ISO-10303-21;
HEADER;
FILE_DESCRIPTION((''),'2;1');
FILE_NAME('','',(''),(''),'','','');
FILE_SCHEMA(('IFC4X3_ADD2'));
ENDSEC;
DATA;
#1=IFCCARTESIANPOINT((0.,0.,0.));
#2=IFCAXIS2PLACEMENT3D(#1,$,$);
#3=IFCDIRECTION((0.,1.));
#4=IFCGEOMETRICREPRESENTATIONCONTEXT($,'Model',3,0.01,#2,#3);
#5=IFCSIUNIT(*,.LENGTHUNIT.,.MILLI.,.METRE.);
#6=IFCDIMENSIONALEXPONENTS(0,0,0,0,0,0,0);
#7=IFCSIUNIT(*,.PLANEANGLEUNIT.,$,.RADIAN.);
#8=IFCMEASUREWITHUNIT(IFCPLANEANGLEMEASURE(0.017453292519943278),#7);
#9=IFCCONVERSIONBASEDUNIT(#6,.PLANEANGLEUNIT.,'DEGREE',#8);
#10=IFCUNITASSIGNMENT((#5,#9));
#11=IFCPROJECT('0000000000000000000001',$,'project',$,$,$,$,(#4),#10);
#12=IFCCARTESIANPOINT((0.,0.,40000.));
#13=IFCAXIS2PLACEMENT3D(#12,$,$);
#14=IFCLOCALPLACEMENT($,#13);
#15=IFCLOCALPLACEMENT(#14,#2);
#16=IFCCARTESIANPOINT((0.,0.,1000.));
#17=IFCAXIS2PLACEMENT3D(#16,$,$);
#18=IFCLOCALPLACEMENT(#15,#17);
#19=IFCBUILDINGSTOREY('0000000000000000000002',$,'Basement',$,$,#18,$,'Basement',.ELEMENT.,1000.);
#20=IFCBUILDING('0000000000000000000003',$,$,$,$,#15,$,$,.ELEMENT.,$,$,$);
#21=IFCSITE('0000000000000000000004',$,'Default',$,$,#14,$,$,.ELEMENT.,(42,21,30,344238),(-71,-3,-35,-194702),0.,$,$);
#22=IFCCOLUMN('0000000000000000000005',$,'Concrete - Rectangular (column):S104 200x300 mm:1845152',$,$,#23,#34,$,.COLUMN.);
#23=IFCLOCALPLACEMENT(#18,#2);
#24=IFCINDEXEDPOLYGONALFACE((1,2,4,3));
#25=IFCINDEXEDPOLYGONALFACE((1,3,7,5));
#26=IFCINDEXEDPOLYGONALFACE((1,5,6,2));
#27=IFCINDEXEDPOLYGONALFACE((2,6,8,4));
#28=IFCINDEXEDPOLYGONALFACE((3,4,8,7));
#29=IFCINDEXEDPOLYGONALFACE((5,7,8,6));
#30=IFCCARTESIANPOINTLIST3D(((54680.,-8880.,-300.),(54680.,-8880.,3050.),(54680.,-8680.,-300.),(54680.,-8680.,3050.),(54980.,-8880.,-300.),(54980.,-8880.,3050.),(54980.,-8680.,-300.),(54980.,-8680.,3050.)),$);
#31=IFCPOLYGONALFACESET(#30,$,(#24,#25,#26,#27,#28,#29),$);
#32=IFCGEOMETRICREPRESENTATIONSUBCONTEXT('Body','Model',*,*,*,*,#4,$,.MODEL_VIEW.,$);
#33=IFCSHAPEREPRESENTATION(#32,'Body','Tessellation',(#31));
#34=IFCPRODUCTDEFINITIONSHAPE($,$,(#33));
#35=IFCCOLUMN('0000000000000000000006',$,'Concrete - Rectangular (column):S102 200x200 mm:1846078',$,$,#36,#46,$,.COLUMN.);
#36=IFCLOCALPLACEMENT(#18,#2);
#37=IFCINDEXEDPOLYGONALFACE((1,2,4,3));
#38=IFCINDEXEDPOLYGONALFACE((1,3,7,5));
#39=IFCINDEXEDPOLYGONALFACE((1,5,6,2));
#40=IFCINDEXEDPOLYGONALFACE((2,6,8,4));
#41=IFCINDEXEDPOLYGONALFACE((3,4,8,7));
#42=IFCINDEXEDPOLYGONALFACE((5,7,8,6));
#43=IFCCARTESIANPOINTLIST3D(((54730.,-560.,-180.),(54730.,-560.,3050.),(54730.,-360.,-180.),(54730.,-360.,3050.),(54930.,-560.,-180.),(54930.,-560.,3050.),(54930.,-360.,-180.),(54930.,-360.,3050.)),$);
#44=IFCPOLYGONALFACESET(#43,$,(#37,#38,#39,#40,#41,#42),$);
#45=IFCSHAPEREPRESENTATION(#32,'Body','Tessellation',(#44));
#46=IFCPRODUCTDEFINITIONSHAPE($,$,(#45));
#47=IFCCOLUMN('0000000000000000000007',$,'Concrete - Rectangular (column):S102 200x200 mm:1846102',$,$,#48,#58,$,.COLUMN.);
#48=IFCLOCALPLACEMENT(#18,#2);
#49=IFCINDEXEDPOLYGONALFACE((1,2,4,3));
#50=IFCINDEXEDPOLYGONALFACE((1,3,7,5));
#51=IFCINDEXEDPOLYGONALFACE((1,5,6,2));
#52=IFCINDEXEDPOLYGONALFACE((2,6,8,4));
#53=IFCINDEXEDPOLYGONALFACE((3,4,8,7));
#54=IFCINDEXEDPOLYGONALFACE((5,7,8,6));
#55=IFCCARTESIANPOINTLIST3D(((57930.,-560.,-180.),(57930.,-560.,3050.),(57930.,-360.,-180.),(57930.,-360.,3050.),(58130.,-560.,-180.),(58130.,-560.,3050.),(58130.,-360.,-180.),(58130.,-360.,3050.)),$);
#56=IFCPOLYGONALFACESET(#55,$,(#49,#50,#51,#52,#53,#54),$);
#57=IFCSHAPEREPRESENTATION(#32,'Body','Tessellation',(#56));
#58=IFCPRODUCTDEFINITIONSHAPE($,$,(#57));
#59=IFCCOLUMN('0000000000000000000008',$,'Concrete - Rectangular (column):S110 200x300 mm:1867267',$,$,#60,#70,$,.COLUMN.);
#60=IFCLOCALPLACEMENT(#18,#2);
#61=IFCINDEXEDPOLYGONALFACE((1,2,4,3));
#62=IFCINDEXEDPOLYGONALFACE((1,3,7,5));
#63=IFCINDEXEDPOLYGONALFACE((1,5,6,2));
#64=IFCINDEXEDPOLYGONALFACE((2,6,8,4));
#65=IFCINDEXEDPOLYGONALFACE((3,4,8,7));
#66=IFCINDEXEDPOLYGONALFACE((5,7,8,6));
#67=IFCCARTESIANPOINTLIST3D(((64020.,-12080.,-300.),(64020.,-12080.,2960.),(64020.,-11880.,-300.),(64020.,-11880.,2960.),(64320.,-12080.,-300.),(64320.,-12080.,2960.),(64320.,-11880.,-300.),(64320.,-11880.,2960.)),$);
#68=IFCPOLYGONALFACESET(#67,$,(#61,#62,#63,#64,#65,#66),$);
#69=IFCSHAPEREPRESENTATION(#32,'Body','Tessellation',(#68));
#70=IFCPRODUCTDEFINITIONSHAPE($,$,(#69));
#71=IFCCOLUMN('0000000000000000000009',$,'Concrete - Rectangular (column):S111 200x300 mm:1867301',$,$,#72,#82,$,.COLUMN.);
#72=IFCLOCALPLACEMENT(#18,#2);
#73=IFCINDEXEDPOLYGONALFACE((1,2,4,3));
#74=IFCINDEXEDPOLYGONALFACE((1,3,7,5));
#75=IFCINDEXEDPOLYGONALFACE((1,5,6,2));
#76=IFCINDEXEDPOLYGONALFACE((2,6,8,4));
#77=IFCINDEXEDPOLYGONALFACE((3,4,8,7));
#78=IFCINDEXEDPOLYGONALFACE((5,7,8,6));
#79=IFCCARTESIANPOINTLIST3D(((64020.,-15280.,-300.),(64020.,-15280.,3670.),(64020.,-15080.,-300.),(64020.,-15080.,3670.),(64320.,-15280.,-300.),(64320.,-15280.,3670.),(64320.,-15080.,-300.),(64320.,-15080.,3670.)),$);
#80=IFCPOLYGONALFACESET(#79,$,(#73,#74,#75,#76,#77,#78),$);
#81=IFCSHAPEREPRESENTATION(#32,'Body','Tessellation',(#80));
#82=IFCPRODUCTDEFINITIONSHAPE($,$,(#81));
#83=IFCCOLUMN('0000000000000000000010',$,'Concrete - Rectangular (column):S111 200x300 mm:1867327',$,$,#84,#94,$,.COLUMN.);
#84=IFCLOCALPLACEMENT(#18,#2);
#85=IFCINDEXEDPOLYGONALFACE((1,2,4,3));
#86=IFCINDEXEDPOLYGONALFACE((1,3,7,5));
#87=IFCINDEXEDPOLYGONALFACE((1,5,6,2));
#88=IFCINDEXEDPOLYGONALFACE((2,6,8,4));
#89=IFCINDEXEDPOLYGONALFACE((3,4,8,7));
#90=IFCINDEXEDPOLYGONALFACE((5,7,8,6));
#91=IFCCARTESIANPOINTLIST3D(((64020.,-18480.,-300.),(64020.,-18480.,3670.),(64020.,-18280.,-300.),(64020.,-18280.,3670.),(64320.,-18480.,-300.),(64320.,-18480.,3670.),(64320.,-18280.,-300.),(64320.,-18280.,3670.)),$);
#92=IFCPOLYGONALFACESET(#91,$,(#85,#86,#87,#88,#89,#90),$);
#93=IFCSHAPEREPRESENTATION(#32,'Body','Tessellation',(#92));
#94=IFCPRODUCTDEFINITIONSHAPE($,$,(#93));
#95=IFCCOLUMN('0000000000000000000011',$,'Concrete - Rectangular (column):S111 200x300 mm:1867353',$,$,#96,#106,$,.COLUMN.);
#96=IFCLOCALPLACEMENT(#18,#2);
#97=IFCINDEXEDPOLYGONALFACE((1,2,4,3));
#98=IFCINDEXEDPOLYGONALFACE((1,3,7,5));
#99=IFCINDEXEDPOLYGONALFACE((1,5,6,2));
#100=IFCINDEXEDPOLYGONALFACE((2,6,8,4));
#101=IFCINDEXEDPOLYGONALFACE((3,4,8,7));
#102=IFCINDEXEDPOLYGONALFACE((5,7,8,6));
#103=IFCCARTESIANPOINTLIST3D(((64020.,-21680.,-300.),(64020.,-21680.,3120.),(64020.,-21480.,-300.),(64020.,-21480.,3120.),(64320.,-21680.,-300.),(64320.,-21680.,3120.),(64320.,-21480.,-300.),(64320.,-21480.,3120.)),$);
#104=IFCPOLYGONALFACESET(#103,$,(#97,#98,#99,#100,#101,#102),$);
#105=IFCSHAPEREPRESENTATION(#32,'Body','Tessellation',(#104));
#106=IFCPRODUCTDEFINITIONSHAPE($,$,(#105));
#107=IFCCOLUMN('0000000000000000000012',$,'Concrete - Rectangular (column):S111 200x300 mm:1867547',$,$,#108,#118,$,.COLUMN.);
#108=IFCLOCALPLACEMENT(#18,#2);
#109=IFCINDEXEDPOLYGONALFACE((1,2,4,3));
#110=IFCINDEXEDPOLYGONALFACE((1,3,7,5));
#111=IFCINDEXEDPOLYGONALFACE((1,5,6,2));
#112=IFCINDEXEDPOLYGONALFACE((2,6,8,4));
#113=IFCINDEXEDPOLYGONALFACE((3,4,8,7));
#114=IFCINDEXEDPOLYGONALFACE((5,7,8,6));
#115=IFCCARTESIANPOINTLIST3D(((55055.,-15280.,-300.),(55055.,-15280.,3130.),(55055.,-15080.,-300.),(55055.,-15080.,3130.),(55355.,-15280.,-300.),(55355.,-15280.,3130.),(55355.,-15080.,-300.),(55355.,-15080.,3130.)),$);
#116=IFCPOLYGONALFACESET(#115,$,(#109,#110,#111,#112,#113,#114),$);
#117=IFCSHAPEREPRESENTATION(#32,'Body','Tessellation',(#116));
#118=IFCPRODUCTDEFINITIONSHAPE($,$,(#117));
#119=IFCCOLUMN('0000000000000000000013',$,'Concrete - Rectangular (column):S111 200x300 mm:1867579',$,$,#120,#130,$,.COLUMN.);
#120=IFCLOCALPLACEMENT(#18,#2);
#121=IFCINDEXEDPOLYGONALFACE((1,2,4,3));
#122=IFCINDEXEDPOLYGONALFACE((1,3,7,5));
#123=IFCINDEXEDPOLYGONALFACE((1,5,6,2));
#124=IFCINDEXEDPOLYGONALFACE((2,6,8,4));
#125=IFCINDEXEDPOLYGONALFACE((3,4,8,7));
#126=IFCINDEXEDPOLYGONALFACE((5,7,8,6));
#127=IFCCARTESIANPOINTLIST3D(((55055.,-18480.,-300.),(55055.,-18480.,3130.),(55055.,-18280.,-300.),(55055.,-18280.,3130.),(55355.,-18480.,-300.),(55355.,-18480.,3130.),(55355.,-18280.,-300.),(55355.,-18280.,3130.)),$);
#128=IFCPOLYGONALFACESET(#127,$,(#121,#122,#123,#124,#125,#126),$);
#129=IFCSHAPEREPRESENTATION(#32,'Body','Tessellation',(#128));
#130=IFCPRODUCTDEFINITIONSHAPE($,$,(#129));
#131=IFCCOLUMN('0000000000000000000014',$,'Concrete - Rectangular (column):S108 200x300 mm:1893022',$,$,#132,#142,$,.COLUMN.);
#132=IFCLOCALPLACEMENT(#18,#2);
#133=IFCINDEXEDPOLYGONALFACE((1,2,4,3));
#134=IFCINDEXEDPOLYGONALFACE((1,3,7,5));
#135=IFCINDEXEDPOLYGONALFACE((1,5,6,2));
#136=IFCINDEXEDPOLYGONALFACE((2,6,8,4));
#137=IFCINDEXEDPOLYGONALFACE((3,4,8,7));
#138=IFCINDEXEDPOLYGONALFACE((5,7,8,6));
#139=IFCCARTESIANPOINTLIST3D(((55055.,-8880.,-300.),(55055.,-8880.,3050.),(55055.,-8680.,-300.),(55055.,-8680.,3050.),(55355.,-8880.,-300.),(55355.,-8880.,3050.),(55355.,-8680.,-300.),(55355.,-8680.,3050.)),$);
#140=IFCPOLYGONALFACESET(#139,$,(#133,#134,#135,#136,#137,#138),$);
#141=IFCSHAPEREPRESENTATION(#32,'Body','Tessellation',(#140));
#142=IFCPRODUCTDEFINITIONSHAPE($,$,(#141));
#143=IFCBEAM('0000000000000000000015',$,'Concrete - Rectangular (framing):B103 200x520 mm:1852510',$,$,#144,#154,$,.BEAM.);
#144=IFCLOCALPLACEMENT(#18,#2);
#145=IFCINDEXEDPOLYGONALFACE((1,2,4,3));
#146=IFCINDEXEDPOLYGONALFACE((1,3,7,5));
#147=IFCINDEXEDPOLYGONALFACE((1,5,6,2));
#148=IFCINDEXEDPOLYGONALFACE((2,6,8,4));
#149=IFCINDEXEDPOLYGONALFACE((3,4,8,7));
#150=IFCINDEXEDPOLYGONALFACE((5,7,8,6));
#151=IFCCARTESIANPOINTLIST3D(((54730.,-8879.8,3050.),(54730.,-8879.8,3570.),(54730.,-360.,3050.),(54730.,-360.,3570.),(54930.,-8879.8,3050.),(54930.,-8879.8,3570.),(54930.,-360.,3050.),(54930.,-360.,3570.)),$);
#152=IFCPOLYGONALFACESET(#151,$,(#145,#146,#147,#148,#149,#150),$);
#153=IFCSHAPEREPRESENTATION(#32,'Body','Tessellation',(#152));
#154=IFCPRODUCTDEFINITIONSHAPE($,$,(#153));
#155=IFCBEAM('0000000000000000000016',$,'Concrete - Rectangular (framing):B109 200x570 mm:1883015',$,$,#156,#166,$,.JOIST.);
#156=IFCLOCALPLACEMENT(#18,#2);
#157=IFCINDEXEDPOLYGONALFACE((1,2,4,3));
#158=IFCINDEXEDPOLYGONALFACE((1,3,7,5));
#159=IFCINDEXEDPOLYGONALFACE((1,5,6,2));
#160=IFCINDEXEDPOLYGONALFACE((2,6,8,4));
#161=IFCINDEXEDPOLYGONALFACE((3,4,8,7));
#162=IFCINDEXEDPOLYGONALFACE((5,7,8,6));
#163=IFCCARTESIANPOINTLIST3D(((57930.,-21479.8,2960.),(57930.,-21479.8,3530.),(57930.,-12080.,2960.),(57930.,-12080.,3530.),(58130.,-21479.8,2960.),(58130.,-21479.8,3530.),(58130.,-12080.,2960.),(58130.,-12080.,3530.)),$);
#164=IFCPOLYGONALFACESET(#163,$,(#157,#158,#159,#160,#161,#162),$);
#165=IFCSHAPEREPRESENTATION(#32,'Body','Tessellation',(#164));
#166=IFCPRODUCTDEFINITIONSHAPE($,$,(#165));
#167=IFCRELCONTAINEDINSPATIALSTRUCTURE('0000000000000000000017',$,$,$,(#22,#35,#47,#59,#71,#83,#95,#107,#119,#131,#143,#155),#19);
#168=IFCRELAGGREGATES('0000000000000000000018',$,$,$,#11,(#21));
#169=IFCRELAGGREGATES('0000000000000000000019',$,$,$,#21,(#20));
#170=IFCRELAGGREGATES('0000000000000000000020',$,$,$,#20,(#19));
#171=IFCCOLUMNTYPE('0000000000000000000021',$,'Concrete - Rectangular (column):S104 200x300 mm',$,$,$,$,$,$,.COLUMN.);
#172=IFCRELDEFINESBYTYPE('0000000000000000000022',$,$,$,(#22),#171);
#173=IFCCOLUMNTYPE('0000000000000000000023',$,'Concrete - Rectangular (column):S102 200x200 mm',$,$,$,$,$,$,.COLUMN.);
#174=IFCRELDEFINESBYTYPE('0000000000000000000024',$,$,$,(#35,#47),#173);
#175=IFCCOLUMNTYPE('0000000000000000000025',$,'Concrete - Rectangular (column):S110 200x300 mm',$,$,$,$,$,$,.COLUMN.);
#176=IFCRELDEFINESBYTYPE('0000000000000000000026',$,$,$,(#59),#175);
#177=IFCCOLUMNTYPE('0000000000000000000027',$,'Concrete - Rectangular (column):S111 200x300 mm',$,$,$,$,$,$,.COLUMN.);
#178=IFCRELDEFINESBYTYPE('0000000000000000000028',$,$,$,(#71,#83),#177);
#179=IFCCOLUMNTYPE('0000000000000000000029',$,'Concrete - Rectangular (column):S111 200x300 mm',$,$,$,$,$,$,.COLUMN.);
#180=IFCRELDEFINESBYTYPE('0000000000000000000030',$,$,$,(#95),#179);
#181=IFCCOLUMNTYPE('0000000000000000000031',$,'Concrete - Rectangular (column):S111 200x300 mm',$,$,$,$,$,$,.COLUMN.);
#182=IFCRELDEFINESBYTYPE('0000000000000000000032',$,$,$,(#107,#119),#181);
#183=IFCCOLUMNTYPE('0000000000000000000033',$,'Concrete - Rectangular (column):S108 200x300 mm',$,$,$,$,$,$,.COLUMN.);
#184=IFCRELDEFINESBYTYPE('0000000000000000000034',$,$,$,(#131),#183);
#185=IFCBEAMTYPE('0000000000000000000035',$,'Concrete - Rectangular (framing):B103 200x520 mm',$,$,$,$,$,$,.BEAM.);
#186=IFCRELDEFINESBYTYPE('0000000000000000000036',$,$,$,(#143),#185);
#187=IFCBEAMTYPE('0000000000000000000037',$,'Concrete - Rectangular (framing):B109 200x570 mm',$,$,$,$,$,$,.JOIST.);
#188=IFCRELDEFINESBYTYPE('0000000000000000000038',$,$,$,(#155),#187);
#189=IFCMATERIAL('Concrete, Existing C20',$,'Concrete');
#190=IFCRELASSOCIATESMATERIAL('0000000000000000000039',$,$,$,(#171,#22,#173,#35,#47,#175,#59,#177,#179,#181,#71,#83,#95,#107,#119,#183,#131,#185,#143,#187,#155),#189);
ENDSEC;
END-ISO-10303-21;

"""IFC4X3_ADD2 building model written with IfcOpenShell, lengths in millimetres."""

from ifc_helpers import new_model, entity, si_unit, converted_unit, direction, frame, frame_2d, origin, origin_2d_with_axis, place, context, subcontext, project, spatial, rectangle, extrude, source, transform, mapped, material, material_profile, profile_set, profile_usage, type_object, type_shapes, element, save


model = new_model("IFC4X3_ADD2")

# Units and contexts
model_context = context("Model", 3, precision=0.01, world=origin(), true_north=direction((0.0, 1.0)))
body_context = subcontext(model_context, "Body", "Model", "MODEL_VIEW")
ifc_project = project(units=[si_unit("LENGTHUNIT", "METRE", prefix="MILLI"), converted_unit("PLANEANGLEUNIT", "DEGREE", entity("IfcPlaneAngleMeasure", 0.017453292519943278), si_unit("PLANEANGLEUNIT", "RADIAN"), dimensions=[0, 0, 0, 0, 0, 0, 0])], contexts=[model_context])

# Site, building, storey
site_placement = place(None, frame((0.0, 0.0, 40000.0)))
site = spatial("IfcSite", under=ifc_project, at=site_placement, Name="Default", CompositionType="ELEMENT", RefLatitude=(42, 21, 30, 344238), RefLongitude=(-71, -3, -35, -194702), RefElevation=0.0)
building_placement = place(site_placement, origin())
building = spatial("IfcBuilding", under=site, at=building_placement, CompositionType="ELEMENT")
storey_placement = place(building_placement, frame((0.0, 0.0, 1000.0)))
storey = spatial("IfcBuildingStorey", under=building, at=storey_placement, Name="Basement", LongName="Basement", CompositionType="ELEMENT", Elevation=1000.0)

# Columns
ifc_material_1 = material(Name="Concrete, Existing C20", Category="Concrete")
ifc_material_profile_1 = material_profile(ifc_material_1, rectangle(XDim=200.0, YDim=300.0, at=frame_2d((0.0, 0.0), x_axis=(1.0, 0.0))), Name="S104 200x300 mm")
ifc_profile_set_1 = profile_set([ifc_material_profile_1], Name="S104 200x300 mm")
ifc_profile_usage_1 = profile_usage(ifc_profile_set_1)
column_type_1 = type_object("IfcColumnType", Name="Concrete - Rectangular (column):S104 200x300 mm", PredefinedType="COLUMN", material=ifc_profile_set_1)
shared_shape_1 = source(origin(), body_context, "Body", "SweptSolid", [
    extrude(rectangle(XDim=200.0, YDim=300.0, at=origin_2d_with_axis()), frame((0.0, 0.0, 700.0), z_axis=(0.0, 0.0, 1.0), x_axis=(-1.0, 0.0, 0.0)), (0.0, 0.0, 1.0), 3350.0),
])
type_shapes(column_type_1, [shared_shape_1])
column_1_placement = place(storey_placement, frame((54830.0, -8780.0, -1000.0), z_axis=(0.0, 0.0, 1.0), x_axis=(0.0, -1.0, 0.0)))
element("IfcColumn", 1, at=column_1_placement, inside=storey, type_object=column_type_1, material=ifc_profile_usage_1, Name="Concrete - Rectangular (column):S104 200x300 mm:1845152", PredefinedType="COLUMN", context=body_context, shape_type="MappedRepresentation", body=[
    mapped(shared_shape_1, transform((0.0, 0.0, 0.0), scale=1.0)),
])
ifc_material_profile_2 = material_profile(ifc_material_1, rectangle(XDim=200.0, YDim=200.0, at=frame_2d((0.0, 0.0), x_axis=(1.0, 0.0))), Name="S102 200x200 mm")
ifc_profile_set_2 = profile_set([ifc_material_profile_2], Name="S102 200x200 mm")
ifc_profile_usage_2 = profile_usage(ifc_profile_set_2)
column_type_2 = type_object("IfcColumnType", Name="Concrete - Rectangular (column):S102 200x200 mm", PredefinedType="COLUMN", material=ifc_profile_set_2)
shared_shape_2 = source(origin(), body_context, "Body", "SweptSolid", [
    extrude(rectangle(XDim=200.0, YDim=200.0, at=origin_2d_with_axis()), frame((0.0, 0.0, 820.0), z_axis=(0.0, 0.0, 1.0), x_axis=(-1.0, 0.0, 0.0)), (0.0, 0.0, 1.0), 3230.0),
])
type_shapes(column_type_2, [shared_shape_2])
for number, where, z_axis, x_axis, name in (
    (2, (54830.0, -460.0, -1000.0), (0.0, 0.0, 1.0), (0.0, -1.0, 0.0), "Concrete - Rectangular (column):S102 200x200 mm:1846078"),
    (3, (58030.0, -460.0, -1000.0), (0.0, 0.0, 1.0), (0.0, -1.0, 0.0), "Concrete - Rectangular (column):S102 200x200 mm:1846102"),
):
    element("IfcColumn", number, at=place(storey_placement, frame(where, z_axis=z_axis, x_axis=x_axis)), inside=storey, type_object=column_type_2, material=ifc_profile_usage_2, Name=name, PredefinedType="COLUMN", context=body_context, shape_type="MappedRepresentation", body=[
        mapped(shared_shape_2, transform((0.0, 0.0, 0.0), scale=1.0)),
    ])
ifc_material_profile_3 = material_profile(ifc_material_1, rectangle(XDim=200.0, YDim=300.0, at=origin_2d_with_axis()), Name="S110 200x300 mm")
ifc_profile_set_3 = profile_set([ifc_material_profile_3], Name="S110 200x300 mm")
ifc_profile_usage_3 = profile_usage(ifc_profile_set_3)
column_type_3 = type_object("IfcColumnType", Name="Concrete - Rectangular (column):S110 200x300 mm", PredefinedType="COLUMN", material=ifc_profile_set_3)
shared_shape_3 = source(origin(), body_context, "Body", "SweptSolid", [
    extrude(rectangle(XDim=200.0, YDim=300.0, at=origin_2d_with_axis()), frame((0.0, 0.0, 700.0), z_axis=(0.0, 0.0, 1.0), x_axis=(-1.0, 0.0, 0.0)), (0.0, 0.0, 1.0), 3260.0),
])
type_shapes(column_type_3, [shared_shape_3])
column_2_placement = place(storey_placement, frame((64170.0, -11980.0, -1000.0), z_axis=(0.0, 0.0, 1.0), x_axis=(0.0, -1.0, 0.0)))
element("IfcColumn", 4, at=column_2_placement, inside=storey, type_object=column_type_3, material=ifc_profile_usage_3, Name="Concrete - Rectangular (column):S110 200x300 mm:1867267", PredefinedType="COLUMN", context=body_context, shape_type="MappedRepresentation", body=[
    mapped(shared_shape_3, transform((0.0, 0.0, 0.0), scale=1.0)),
])
ifc_material_profile_4 = material_profile(ifc_material_1, rectangle(XDim=200.0, YDim=300.0, at=origin_2d_with_axis()), Name="S111 200x300 mm")
ifc_profile_set_4 = profile_set([ifc_material_profile_4], Name="S111 200x300 mm")
ifc_profile_usage_4 = profile_usage(ifc_profile_set_4)
column_type_4 = type_object("IfcColumnType", Name="Concrete - Rectangular (column):S111 200x300 mm", PredefinedType="COLUMN", material=ifc_profile_set_4)
shared_shape_4 = source(origin(), body_context, "Body", "SweptSolid", [
    extrude(rectangle(XDim=200.0, YDim=300.0, at=origin_2d_with_axis()), frame((0.0, 0.0, 700.0), z_axis=(0.0, 0.0, 1.0), x_axis=(-1.0, 0.0, 0.0)), (0.0, 0.0, 1.0), 3970.0),
])
type_shapes(column_type_4, [shared_shape_4])
for number, where, z_axis, x_axis, name in (
    (5, (64170.0, -15180.0, -1000.0), (0.0, 0.0, 1.0), (0.0, -1.0, 0.0), "Concrete - Rectangular (column):S111 200x300 mm:1867301"),
    (6, (64170.0, -18380.0, -1000.0), (0.0, 0.0, 1.0), (0.0, -1.0, 0.0), "Concrete - Rectangular (column):S111 200x300 mm:1867327"),
):
    element("IfcColumn", number, at=place(storey_placement, frame(where, z_axis=z_axis, x_axis=x_axis)), inside=storey, type_object=column_type_4, material=ifc_profile_usage_4, Name=name, PredefinedType="COLUMN", context=body_context, shape_type="MappedRepresentation", body=[
        mapped(shared_shape_4, transform((0.0, 0.0, 0.0), scale=1.0)),
    ])
column_type_5 = type_object("IfcColumnType", Name="Concrete - Rectangular (column):S111 200x300 mm", PredefinedType="COLUMN", material=ifc_profile_set_4)
shared_shape_5 = source(origin(), body_context, "Body", "SweptSolid", [
    extrude(rectangle(XDim=200.0, YDim=300.0, at=origin_2d_with_axis()), frame((0.0, 0.0, 700.0), z_axis=(0.0, 0.0, 1.0), x_axis=(-1.0, 0.0, 0.0)), (0.0, 0.0, 1.0), 3420.0),
])
type_shapes(column_type_5, [shared_shape_5])
column_3_placement = place(storey_placement, frame((64170.0, -21580.0, -1000.0), z_axis=(0.0, 0.0, 1.0), x_axis=(0.0, -1.0, 0.0)))
element("IfcColumn", 7, at=column_3_placement, inside=storey, type_object=column_type_5, material=ifc_profile_usage_4, Name="Concrete - Rectangular (column):S111 200x300 mm:1867353", PredefinedType="COLUMN", context=body_context, shape_type="MappedRepresentation", body=[
    mapped(shared_shape_5, transform((0.0, 0.0, 0.0), scale=1.0)),
])
column_type_6 = type_object("IfcColumnType", Name="Concrete - Rectangular (column):S111 200x300 mm", PredefinedType="COLUMN", material=ifc_profile_set_4)
shared_shape_6 = source(origin(), body_context, "Body", "SweptSolid", [
    extrude(rectangle(XDim=200.0, YDim=300.0, at=origin_2d_with_axis()), frame((0.0, 0.0, 700.0), z_axis=(0.0, 0.0, 1.0), x_axis=(-1.0, 0.0, 0.0)), (0.0, 0.0, 1.0), 3430.0),
])
type_shapes(column_type_6, [shared_shape_6])
for number, where, z_axis, x_axis, name in (
    (8, (55205.0, -15180.0, -1000.0), (0.0, 0.0, 1.0), (0.0, -1.0, 0.0), "Concrete - Rectangular (column):S111 200x300 mm:1867547"),
    (9, (55205.0, -18380.0, -1000.0), (0.0, 0.0, 1.0), (0.0, -1.0, 0.0), "Concrete - Rectangular (column):S111 200x300 mm:1867579"),
):
    element("IfcColumn", number, at=place(storey_placement, frame(where, z_axis=z_axis, x_axis=x_axis)), inside=storey, type_object=column_type_6, material=ifc_profile_usage_4, Name=name, PredefinedType="COLUMN", context=body_context, shape_type="MappedRepresentation", body=[
        mapped(shared_shape_6, transform((0.0, 0.0, 0.0), scale=1.0)),
    ])
ifc_material_profile_5 = material_profile(ifc_material_1, rectangle(XDim=200.0, YDim=300.0, at=origin_2d_with_axis()), Name="S108 200x300 mm")
ifc_profile_set_5 = profile_set([ifc_material_profile_5], Name="S108 200x300 mm")
ifc_profile_usage_5 = profile_usage(ifc_profile_set_5)
column_type_7 = type_object("IfcColumnType", Name="Concrete - Rectangular (column):S108 200x300 mm", PredefinedType="COLUMN", material=ifc_profile_set_5)
shared_shape_7 = source(origin(), body_context, "Body", "SweptSolid", [
    extrude(rectangle(XDim=200.0, YDim=300.0, at=origin_2d_with_axis()), frame((0.0, 0.0, 700.0), z_axis=(0.0, 0.0, 1.0), x_axis=(-1.0, 0.0, 0.0)), (0.0, 0.0, 1.0), 3350.0),
])
type_shapes(column_type_7, [shared_shape_7])
column_4_placement = place(storey_placement, frame((55205.0, -8780.0, -1000.0), z_axis=(0.0, 0.0, 1.0), x_axis=(0.0, -1.0, 0.0)))
element("IfcColumn", 10, at=column_4_placement, inside=storey, type_object=column_type_7, material=ifc_profile_usage_5, Name="Concrete - Rectangular (column):S108 200x300 mm:1893022", PredefinedType="COLUMN", context=body_context, shape_type="MappedRepresentation", body=[
    mapped(shared_shape_7, transform((0.0, 0.0, 0.0), scale=1.0)),
])

# Beams
ifc_material_profile_6 = material_profile(ifc_material_1, rectangle(XDim=8519.8, YDim=200.0, at=origin_2d_with_axis()), Name="B103 200x520 mm")
ifc_profile_set_6 = profile_set([ifc_material_profile_6], Name="B103 200x520 mm")
ifc_profile_usage_6 = profile_usage(ifc_profile_set_6, cardinal=8)
beam_type_1 = type_object("IfcBeamType", Name="Concrete - Rectangular (framing):B103 200x520 mm", PredefinedType="BEAM", material=ifc_profile_set_6)
shared_shape_8 = source(origin(), body_context, "Body", "SweptSolid", [
    extrude(rectangle(XDim=8519.8, YDim=200.0, at=origin_2d_with_axis()), frame((-0.1, 0.0, -260.0), z_axis=(0.0, 0.0, 1.0), x_axis=(-1.0, 0.0, 0.0)), (0.0, 0.0, 1.0), 520.0),
])
type_shapes(beam_type_1, [shared_shape_8])
beam_1_placement = place(storey_placement, frame((54830.0, -4620.0, 3310.0), z_axis=(0.0, 0.0, 1.0), x_axis=(0.0, -1.0, 0.0)))
element("IfcBeam", 11, at=beam_1_placement, inside=storey, type_object=beam_type_1, material=ifc_profile_usage_6, Name="Concrete - Rectangular (framing):B103 200x520 mm:1852510", PredefinedType="BEAM", context=body_context, shape_type="MappedRepresentation", body=[
    mapped(shared_shape_8, transform((0.0, 0.0, 0.0), scale=1.0)),
])
ifc_material_profile_7 = material_profile(ifc_material_1, rectangle(XDim=9399.8, YDim=200.0, at=origin_2d_with_axis()), Name="B109 200x570 mm")
ifc_profile_set_7 = profile_set([ifc_material_profile_7], Name="B109 200x570 mm")
ifc_profile_usage_7 = profile_usage(ifc_profile_set_7, cardinal=8)
beam_type_2 = type_object("IfcBeamType", Name="Concrete - Rectangular (framing):B109 200x570 mm", PredefinedType="JOIST", material=ifc_profile_set_7)
shared_shape_9 = source(origin(), body_context, "Body", "SweptSolid", [
    extrude(rectangle(XDim=9399.8, YDim=200.0, at=origin_2d_with_axis()), frame((-0.1, 0.0, -285.0), z_axis=(0.0, 0.0, 1.0), x_axis=(-1.0, 0.0, 0.0)), (0.0, 0.0, 1.0), 570.0),
])
type_shapes(beam_type_2, [shared_shape_9])
beam_2_placement = place(storey_placement, frame((58030.0, -16780.0, 3245.0), z_axis=(0.0, 0.0, 1.0), x_axis=(0.0, -1.0, 0.0)))
element("IfcBeam", 12, at=beam_2_placement, inside=storey, type_object=beam_type_2, material=ifc_profile_usage_7, Name="Concrete - Rectangular (framing):B109 200x570 mm:1883015", PredefinedType="JOIST", context=body_context, shape_type="MappedRepresentation", body=[
    mapped(shared_shape_9, transform((0.0, 0.0, 0.0), scale=1.0)),
])

save(model, "model.ifc")
